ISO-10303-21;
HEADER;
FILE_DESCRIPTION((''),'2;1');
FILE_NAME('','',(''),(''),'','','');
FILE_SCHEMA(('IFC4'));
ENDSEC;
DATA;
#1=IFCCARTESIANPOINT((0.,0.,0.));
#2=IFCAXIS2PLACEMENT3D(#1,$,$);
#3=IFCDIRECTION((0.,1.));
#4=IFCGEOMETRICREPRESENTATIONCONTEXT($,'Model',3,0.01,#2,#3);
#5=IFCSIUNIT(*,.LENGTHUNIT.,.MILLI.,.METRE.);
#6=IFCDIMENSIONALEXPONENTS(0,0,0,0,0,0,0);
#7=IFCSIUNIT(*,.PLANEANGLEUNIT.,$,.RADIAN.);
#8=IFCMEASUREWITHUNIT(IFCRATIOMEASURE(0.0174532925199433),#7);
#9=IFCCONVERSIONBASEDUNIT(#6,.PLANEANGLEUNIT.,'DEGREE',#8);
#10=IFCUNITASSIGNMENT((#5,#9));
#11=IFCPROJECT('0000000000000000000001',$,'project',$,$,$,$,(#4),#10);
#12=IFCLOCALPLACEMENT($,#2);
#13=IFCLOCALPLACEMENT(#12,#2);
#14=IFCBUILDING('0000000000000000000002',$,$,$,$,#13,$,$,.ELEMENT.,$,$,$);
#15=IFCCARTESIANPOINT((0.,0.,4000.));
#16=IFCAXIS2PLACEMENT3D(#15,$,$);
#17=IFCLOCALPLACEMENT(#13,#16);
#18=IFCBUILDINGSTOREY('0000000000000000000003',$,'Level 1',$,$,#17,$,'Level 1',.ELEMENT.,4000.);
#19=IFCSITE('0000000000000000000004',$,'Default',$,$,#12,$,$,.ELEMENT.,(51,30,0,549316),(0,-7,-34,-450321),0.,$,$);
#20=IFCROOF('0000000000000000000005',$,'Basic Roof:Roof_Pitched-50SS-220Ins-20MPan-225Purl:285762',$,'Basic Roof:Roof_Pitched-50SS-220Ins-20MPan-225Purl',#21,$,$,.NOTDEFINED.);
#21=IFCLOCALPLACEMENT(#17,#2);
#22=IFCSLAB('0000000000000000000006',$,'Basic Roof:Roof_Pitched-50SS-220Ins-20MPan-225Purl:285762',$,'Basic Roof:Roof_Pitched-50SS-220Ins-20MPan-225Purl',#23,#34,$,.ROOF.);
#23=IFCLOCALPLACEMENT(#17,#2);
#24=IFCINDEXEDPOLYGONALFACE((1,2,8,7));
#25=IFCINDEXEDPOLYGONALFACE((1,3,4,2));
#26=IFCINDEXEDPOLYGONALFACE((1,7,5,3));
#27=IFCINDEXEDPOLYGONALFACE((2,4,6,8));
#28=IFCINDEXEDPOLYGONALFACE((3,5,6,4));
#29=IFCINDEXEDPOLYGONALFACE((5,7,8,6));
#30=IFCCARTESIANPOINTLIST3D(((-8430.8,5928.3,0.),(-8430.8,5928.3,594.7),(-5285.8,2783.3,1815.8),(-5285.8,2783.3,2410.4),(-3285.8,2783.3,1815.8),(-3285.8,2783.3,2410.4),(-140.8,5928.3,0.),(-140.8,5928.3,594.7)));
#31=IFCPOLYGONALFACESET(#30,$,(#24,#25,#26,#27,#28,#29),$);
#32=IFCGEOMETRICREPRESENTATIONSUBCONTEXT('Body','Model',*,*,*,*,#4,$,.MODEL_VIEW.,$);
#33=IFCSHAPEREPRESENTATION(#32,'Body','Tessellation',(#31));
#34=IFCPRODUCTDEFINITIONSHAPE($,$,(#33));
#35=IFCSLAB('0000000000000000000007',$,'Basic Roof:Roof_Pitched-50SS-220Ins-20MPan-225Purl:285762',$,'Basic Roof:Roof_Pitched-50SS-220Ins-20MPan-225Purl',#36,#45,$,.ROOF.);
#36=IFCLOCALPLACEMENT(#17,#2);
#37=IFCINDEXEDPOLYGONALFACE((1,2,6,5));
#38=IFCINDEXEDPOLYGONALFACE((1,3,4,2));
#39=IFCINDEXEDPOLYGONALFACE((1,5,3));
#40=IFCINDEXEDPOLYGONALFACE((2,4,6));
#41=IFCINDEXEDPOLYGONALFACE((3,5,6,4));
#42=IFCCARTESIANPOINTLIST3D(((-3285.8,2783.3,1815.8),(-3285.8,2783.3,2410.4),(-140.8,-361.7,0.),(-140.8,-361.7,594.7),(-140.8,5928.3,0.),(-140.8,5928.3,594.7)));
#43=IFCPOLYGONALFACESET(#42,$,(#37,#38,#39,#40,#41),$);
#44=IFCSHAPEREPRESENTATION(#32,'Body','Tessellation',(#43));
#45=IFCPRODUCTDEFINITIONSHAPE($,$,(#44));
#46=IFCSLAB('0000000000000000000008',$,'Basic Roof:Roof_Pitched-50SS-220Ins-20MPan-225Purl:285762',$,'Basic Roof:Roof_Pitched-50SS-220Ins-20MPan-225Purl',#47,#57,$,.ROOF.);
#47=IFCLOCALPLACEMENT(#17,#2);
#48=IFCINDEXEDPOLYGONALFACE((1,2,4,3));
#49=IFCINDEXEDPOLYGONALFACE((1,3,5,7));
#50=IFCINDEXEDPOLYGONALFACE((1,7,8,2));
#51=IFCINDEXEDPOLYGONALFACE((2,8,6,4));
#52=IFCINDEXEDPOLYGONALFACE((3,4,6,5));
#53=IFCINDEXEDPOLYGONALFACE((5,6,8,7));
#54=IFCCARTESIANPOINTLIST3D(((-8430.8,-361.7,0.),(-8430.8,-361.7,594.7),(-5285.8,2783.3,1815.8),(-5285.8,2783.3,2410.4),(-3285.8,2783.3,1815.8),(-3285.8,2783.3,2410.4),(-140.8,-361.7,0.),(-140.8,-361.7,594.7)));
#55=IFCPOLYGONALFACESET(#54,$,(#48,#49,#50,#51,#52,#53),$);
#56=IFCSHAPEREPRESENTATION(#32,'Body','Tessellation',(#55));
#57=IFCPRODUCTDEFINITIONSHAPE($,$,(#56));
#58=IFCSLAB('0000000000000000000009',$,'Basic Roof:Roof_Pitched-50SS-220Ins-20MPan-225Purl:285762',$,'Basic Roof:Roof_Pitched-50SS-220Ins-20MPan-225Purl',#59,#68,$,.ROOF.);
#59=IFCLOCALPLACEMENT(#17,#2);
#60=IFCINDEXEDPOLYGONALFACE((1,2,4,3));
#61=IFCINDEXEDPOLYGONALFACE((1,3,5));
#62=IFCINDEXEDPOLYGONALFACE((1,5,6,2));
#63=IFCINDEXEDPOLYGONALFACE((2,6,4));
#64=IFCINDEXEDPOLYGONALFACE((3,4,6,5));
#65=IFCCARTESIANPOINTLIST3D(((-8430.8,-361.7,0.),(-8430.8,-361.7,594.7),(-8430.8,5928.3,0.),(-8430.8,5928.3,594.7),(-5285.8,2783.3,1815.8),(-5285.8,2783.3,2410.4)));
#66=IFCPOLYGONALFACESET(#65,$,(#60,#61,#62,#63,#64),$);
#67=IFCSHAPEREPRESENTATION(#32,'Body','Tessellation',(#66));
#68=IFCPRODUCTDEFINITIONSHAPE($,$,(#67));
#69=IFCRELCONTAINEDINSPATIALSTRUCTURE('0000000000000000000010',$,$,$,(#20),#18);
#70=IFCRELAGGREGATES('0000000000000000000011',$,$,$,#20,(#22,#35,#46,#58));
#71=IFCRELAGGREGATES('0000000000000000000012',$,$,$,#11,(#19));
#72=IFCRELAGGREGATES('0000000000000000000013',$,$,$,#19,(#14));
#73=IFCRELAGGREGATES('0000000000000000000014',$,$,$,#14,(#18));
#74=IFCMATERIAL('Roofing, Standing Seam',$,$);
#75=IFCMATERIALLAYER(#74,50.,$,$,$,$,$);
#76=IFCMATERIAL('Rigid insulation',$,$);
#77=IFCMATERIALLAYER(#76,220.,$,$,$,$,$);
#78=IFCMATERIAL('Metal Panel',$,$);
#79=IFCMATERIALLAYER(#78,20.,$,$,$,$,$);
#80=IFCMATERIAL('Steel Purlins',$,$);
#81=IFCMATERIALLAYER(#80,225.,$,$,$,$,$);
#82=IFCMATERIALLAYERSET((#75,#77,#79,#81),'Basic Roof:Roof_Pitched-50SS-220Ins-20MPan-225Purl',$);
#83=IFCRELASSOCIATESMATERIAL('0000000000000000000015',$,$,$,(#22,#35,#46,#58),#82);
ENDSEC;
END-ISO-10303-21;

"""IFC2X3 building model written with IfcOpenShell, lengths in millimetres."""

from ifc_helpers import new_model, entity, si_unit, converted_unit, direction, frame, origin, place, context, subcontext, project, spatial, polyline, outline, extrude, material, layer, layer_set, element, aggregate, save


model = new_model("IFC2X3")

# Units and contexts
model_context = context("Model", 3, precision=0.01, world=origin(), true_north=direction((0.0, 1.0)))
body_context = subcontext(model_context, "Body", "Model", "MODEL_VIEW")
ifc_project = project(units=[si_unit("LENGTHUNIT", "METRE", prefix="MILLI"), converted_unit("PLANEANGLEUNIT", "DEGREE", entity("IfcRatioMeasure", 0.0174532925199433), si_unit("PLANEANGLEUNIT", "RADIAN"), dimensions=[0, 0, 0, 0, 0, 0, 0])], contexts=[model_context])

# Site, building, storey
site_placement = place(None, origin())
site = spatial("IfcSite", under=ifc_project, at=site_placement, Name="Default", CompositionType="ELEMENT", RefLatitude=(51, 30, 0, 549316), RefLongitude=(0, -7, -34, -450321), RefElevation=0.0)
building_placement = place(site_placement, origin())
building = spatial("IfcBuilding", under=site, at=building_placement, CompositionType="ELEMENT")
storey_placement = place(building_placement, frame((0.0, 0.0, 4000.0)))
storey = spatial("IfcBuildingStorey", under=building, at=storey_placement, Name="Level 1", LongName="Level 1", CompositionType="ELEMENT", Elevation=4000.0)

# Roof, slabs
roof_placement = place(storey_placement, frame((-8430.8, -361.7, 0.0)))
roof = element("IfcRoof", 1, at=roof_placement, inside=storey, Name="Basic Roof:Roof_Pitched-50SS-220Ins-20MPan-225Purl:285762", ObjectType="Basic Roof:Roof_Pitched-50SS-220Ins-20MPan-225Purl", ShapeType="NOTDEFINED")
ifc_material_1 = material(Name="Roofing, Standing Seam")
ifc_layer_1 = layer(ifc_material_1, 50.0)
ifc_material_2 = material(Name="Rigid insulation")
ifc_layer_2 = layer(ifc_material_2, 220.0)
ifc_material_3 = material(Name="Metal Panel")
ifc_layer_3 = layer(ifc_material_3, 20.0)
ifc_material_4 = material(Name="Steel Purlins")
ifc_layer_4 = layer(ifc_material_4, 225.0)
ifc_layer_set = layer_set([ifc_layer_1, ifc_layer_2, ifc_layer_3, ifc_layer_4], Name="Basic Roof:Roof_Pitched-50SS-220Ins-20MPan-225Purl")
slab_1_placement = place(roof_placement, origin())
slab_1 = element("IfcSlab", 2, at=slab_1_placement, material=ifc_layer_set, Name="Basic Roof:Roof_Pitched-50SS-220Ins-20MPan-225Purl:285762", ObjectType="Basic Roof:Roof_Pitched-50SS-220Ins-20MPan-225Purl", PredefinedType="ROOF", context=body_context, shape_type="SweptSolid", body=[
    extrude(outline(polyline([(4145.0, 1815.8), (-4145.0, 1815.8), (-1000.0, -1815.8), (1000.0, -1815.8), (4145.0, 1815.8)])), frame((4145.0, 4717.5, 907.9), z_axis=(0.0, 0.5, 0.866025), x_axis=(1.0, 0.0, 0.0)), (0.0, -0.5, 0.866025), 594.7),
])
slab_2_placement = place(roof_placement, origin())
slab_2 = element("IfcSlab", 3, at=slab_2_placement, material=ifc_layer_set, Name="Basic Roof:Roof_Pitched-50SS-220Ins-20MPan-225Purl:285762", ObjectType="Basic Roof:Roof_Pitched-50SS-220Ins-20MPan-225Purl", PredefinedType="ROOF", context=body_context, shape_type="SweptSolid", body=[
    extrude(outline(polyline([(-1815.8, 0.0), (1815.8, -3145.0), (1815.8, 3145.0), (-1815.8, 0.0)])), frame((6717.5, 3145.0, 907.9), z_axis=(0.5, 0.0, 0.866025), x_axis=(0.866025, 0.0, -0.5)), (-0.5, 0.0, 0.866025), 594.7),
])
slab_3_placement = place(roof_placement, origin())
slab_3 = element("IfcSlab", 4, at=slab_3_placement, material=ifc_layer_set, Name="Basic Roof:Roof_Pitched-50SS-220Ins-20MPan-225Purl:285762", ObjectType="Basic Roof:Roof_Pitched-50SS-220Ins-20MPan-225Purl", PredefinedType="ROOF", context=body_context, shape_type="SweptSolid", body=[
    extrude(outline(polyline([(-4145.0, -1815.8), (4145.0, -1815.8), (1000.0, 1815.8), (-1000.0, 1815.8), (-4145.0, -1815.8)])), frame((4145.0, 1572.5, 907.9), z_axis=(0.0, -0.5, 0.866025), x_axis=(1.0, 0.0, 0.0)), (0.0, 0.5, 0.866025), 594.7),
])
slab_4_placement = place(roof_placement, origin())
slab_4 = element("IfcSlab", 5, at=slab_4_placement, material=ifc_layer_set, Name="Basic Roof:Roof_Pitched-50SS-220Ins-20MPan-225Purl:285762", ObjectType="Basic Roof:Roof_Pitched-50SS-220Ins-20MPan-225Purl", PredefinedType="ROOF", context=body_context, shape_type="SweptSolid", body=[
    extrude(outline(polyline([(-1815.8, 3145.0), (-1815.8, -3145.0), (1815.8, 0.0), (-1815.8, 3145.0)])), frame((1572.5, 3145.0, 907.9), z_axis=(-0.5, 0.0, 0.866025), x_axis=(0.866025, 0.0, 0.5)), (0.5, 0.0, 0.866025), 594.7),
])
aggregate(roof, [slab_1, slab_2, slab_3, slab_4])

save(model, "model.ifc")
